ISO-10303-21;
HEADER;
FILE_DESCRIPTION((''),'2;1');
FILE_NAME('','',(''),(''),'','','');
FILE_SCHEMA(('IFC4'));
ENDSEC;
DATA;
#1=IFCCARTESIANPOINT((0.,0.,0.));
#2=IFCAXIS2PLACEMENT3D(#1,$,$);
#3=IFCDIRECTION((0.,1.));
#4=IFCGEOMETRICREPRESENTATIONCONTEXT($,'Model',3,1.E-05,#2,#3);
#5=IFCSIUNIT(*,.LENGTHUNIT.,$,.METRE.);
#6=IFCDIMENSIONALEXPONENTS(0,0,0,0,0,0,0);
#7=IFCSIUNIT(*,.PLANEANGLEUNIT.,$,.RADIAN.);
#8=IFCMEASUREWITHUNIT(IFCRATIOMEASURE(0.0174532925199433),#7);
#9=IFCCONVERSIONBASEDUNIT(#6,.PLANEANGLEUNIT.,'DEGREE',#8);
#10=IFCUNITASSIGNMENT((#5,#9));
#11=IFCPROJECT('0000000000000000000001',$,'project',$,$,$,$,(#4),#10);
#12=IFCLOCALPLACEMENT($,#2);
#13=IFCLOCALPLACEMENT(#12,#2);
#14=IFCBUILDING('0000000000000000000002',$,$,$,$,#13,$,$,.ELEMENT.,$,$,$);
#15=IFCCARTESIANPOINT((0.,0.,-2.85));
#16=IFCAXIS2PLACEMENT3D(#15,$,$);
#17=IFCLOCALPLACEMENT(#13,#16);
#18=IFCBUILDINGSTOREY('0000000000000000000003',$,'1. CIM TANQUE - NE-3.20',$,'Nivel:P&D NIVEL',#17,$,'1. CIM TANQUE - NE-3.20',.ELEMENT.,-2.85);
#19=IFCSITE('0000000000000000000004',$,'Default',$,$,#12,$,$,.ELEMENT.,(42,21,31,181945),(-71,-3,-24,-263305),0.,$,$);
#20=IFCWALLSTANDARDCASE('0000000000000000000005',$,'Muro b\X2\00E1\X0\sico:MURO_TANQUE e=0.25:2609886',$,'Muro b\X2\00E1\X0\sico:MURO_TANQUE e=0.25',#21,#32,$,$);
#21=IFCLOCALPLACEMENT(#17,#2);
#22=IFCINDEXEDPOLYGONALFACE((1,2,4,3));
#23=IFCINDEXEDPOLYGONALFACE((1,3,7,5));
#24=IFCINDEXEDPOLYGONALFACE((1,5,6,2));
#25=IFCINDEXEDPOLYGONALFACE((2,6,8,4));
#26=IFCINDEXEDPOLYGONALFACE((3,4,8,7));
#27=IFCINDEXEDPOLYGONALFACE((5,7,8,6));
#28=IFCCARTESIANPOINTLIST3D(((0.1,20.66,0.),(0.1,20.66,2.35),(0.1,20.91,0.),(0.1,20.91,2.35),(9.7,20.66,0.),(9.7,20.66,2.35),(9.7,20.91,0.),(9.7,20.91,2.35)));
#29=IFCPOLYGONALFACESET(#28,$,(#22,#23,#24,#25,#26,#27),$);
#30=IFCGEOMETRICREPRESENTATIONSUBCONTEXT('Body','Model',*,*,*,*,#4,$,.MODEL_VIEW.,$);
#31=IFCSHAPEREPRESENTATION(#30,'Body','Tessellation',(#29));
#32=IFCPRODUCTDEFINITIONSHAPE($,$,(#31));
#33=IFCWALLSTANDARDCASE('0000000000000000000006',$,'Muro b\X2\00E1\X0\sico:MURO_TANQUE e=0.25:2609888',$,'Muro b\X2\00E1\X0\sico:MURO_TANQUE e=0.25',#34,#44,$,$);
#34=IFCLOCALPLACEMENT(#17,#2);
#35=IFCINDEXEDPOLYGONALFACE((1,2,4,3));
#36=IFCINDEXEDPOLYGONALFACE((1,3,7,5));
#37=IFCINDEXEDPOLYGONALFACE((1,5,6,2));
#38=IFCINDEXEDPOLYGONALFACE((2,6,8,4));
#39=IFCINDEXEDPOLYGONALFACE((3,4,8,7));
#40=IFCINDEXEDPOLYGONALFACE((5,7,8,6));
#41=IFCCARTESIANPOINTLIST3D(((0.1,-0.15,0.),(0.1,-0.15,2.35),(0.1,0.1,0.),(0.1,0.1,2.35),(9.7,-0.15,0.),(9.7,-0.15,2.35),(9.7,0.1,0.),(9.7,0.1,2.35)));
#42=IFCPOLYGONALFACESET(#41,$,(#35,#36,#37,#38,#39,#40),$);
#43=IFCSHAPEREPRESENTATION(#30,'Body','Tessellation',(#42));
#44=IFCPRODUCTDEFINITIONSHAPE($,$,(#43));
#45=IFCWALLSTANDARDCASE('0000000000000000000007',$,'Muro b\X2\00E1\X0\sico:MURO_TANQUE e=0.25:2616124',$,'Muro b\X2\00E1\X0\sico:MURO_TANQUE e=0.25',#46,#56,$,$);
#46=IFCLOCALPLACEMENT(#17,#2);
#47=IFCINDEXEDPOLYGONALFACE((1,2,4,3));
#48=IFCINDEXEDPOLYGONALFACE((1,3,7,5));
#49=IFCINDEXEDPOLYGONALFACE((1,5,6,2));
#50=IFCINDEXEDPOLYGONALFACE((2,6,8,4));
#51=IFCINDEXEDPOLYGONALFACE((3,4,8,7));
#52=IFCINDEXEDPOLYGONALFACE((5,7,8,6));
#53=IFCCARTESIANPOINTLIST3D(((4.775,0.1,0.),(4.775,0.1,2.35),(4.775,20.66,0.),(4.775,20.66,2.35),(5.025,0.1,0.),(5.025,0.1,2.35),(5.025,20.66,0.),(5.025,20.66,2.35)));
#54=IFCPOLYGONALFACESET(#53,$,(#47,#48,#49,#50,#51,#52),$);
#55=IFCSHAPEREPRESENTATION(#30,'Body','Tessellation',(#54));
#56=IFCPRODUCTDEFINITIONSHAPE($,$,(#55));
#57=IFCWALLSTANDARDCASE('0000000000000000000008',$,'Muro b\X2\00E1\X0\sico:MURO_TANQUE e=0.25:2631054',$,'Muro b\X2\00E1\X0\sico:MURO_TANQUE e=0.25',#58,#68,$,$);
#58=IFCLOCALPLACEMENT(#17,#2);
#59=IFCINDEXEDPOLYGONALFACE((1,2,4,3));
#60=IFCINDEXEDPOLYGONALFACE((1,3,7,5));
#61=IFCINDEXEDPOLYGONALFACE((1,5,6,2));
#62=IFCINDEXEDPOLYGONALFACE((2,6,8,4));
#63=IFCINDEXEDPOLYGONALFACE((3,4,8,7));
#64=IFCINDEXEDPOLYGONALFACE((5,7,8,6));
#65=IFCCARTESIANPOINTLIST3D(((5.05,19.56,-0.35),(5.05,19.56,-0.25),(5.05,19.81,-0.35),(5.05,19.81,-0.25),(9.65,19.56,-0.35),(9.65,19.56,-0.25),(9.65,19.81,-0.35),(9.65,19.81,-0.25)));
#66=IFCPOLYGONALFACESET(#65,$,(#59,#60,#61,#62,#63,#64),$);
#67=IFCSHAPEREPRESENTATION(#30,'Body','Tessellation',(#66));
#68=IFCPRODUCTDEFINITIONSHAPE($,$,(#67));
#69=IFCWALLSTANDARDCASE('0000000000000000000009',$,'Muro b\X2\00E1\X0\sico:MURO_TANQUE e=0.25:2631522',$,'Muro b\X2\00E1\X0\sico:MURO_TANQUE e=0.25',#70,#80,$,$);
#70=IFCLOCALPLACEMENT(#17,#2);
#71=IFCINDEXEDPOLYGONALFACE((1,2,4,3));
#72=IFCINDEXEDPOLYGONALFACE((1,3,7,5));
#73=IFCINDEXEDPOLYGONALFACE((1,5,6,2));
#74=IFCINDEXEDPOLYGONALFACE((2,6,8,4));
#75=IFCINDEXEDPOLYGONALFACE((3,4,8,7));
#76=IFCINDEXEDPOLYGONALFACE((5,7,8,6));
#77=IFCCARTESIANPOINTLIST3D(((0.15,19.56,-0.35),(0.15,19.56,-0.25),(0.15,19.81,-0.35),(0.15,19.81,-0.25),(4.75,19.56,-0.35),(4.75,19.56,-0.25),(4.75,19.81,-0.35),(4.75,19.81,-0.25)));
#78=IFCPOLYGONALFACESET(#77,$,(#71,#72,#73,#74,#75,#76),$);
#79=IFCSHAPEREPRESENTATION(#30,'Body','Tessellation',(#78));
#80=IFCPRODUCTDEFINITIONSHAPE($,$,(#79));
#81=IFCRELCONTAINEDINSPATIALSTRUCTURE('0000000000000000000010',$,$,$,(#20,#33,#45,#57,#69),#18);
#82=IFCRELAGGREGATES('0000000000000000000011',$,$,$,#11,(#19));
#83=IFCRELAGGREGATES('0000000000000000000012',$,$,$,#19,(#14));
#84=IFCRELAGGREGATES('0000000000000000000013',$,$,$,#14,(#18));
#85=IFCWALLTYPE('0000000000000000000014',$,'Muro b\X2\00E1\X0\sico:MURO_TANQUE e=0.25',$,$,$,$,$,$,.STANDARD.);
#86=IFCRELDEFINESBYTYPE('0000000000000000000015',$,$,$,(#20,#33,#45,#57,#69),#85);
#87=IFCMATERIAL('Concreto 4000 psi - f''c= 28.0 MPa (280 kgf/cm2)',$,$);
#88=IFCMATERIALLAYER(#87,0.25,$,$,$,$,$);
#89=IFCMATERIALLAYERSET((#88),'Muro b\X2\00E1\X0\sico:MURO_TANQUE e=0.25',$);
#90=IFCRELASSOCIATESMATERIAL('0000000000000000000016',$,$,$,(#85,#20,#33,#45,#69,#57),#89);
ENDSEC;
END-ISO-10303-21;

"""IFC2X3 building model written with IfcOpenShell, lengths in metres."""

from ifc_helpers import new_model, entity, si_unit, converted_unit, direction, frame, frame_2d, origin, place, context, subcontext, project, spatial, rectangle, extrude, material, layer, layer_set, layer_usage, type_object, element, save


model = new_model("IFC2X3")

# Units and contexts
model_context = context("Model", 3, precision=1e-05, world=origin(), true_north=direction((0.0, 1.0)))
body_context = subcontext(model_context, "Body", "Model", "MODEL_VIEW")
ifc_project = project(units=[si_unit("LENGTHUNIT", "METRE"), converted_unit("PLANEANGLEUNIT", "DEGREE", entity("IfcRatioMeasure", 0.0174532925199433), si_unit("PLANEANGLEUNIT", "RADIAN"), dimensions=[0, 0, 0, 0, 0, 0, 0])], contexts=[model_context])

# Site, building, storey
site_placement = place(None, origin())
site = spatial("IfcSite", under=ifc_project, at=site_placement, Name="Default", CompositionType="ELEMENT", RefLatitude=(42, 21, 31, 181945), RefLongitude=(-71, -3, -24, -263305), RefElevation=0.0)
building_placement = place(site_placement, origin())
building = spatial("IfcBuilding", under=site, at=building_placement, CompositionType="ELEMENT")
storey_placement = place(building_placement, frame((0.0, 0.0, -2.85)))
storey = spatial("IfcBuildingStorey", under=building, at=storey_placement, Name="1. CIM TANQUE - NE-3.20", ObjectType="Nivel:P&D NIVEL", LongName="1. CIM TANQUE - NE-3.20", CompositionType="ELEMENT", Elevation=-2.85)

# Shared definitions
ifc_material = material(Name="Concreto 4000 psi - f'c= 28.0 MPa (280 kgf/cm2)")

# Walls
ifc_layer_1 = layer(ifc_material, 0.25)
ifc_layer_set_1 = layer_set([ifc_layer_1], Name="Muro básico:MURO_TANQUE e=0.25")
ifc_layer_usage_1 = layer_usage(ifc_layer_set_1, "AXIS2", "NEGATIVE", 0.125)
wall_type = type_object("IfcWallType", Name="Muro básico:MURO_TANQUE e=0.25", PredefinedType="STANDARD", material=ifc_layer_set_1)
wall_1_placement = place(storey_placement, frame((9.7, 20.785, 0.0), z_axis=(0.0, 0.0, 1.0), x_axis=(-1.0, 0.0, 0.0)))
element("IfcWallStandardCase", 1, at=wall_1_placement, inside=storey, type_object=wall_type, material=ifc_layer_usage_1, Name="Muro básico:MURO_TANQUE e=0.25:2609886", ObjectType="Muro básico:MURO_TANQUE e=0.25", context=body_context, shape_type="SweptSolid", body=[
    extrude(rectangle(XDim=9.6, YDim=0.25, at=frame_2d((4.8, 0.0), x_axis=(-1.0, 0.0))), origin(), (0.0, 0.0, 1.0), 2.35),
])
wall_2_placement = place(storey_placement, frame((9.7, -0.025, 0.0), z_axis=(0.0, 0.0, 1.0), x_axis=(-1.0, 0.0, 0.0)))
element("IfcWallStandardCase", 2, at=wall_2_placement, inside=storey, type_object=wall_type, material=ifc_layer_usage_1, Name="Muro básico:MURO_TANQUE e=0.25:2609888", ObjectType="Muro básico:MURO_TANQUE e=0.25", context=body_context, shape_type="SweptSolid", body=[
    extrude(rectangle(XDim=9.6, YDim=0.25, at=frame_2d((4.8, 0.0), x_axis=(-1.0, 0.0))), origin(), (0.0, 0.0, 1.0), 2.35),
])
wall_3_placement = place(storey_placement, frame((4.9, 20.66, 0.0), z_axis=(0.0, 0.0, 1.0), x_axis=(0.0, -1.0, 0.0)))
element("IfcWallStandardCase", 3, at=wall_3_placement, inside=storey, type_object=wall_type, material=ifc_layer_usage_1, Name="Muro básico:MURO_TANQUE e=0.25:2616124", ObjectType="Muro básico:MURO_TANQUE e=0.25", context=body_context, shape_type="SweptSolid", body=[
    extrude(rectangle(XDim=20.56, YDim=0.25, at=frame_2d((10.28, 0.0), x_axis=(-1.0, 0.0))), origin(), (0.0, 0.0, 1.0), 2.35),
])
ifc_layer_usage_2 = layer_usage(ifc_layer_set_1, "AXIS2", "POSITIVE", -0.125)
wall_4_placement = place(storey_placement, frame((5.05, 19.685, -0.35)))
element("IfcWallStandardCase", 4, at=wall_4_placement, inside=storey, type_object=wall_type, material=ifc_layer_usage_2, Name="Muro básico:MURO_TANQUE e=0.25:2631054", ObjectType="Muro básico:MURO_TANQUE e=0.25", context=body_context, shape_type="SweptSolid", body=[
    extrude(rectangle(XDim=4.6, YDim=0.25, at=frame_2d((2.3, 0.0), x_axis=(-1.0, 0.0))), origin(), (0.0, 0.0, 1.0), 0.1),
])
wall_5_placement = place(storey_placement, frame((4.75, 19.685, -0.35), z_axis=(0.0, 0.0, 1.0), x_axis=(-1.0, 0.0, 0.0)))
element("IfcWallStandardCase", 5, at=wall_5_placement, inside=storey, type_object=wall_type, material=ifc_layer_usage_1, Name="Muro básico:MURO_TANQUE e=0.25:2631522", ObjectType="Muro básico:MURO_TANQUE e=0.25", context=body_context, shape_type="SweptSolid", body=[
    extrude(rectangle(XDim=4.6, YDim=0.25, at=frame_2d((2.3, 0.0), x_axis=(-1.0, 0.0))), origin(), (0.0, 0.0, 1.0), 0.1),
])

save(model, "model.ifc")
